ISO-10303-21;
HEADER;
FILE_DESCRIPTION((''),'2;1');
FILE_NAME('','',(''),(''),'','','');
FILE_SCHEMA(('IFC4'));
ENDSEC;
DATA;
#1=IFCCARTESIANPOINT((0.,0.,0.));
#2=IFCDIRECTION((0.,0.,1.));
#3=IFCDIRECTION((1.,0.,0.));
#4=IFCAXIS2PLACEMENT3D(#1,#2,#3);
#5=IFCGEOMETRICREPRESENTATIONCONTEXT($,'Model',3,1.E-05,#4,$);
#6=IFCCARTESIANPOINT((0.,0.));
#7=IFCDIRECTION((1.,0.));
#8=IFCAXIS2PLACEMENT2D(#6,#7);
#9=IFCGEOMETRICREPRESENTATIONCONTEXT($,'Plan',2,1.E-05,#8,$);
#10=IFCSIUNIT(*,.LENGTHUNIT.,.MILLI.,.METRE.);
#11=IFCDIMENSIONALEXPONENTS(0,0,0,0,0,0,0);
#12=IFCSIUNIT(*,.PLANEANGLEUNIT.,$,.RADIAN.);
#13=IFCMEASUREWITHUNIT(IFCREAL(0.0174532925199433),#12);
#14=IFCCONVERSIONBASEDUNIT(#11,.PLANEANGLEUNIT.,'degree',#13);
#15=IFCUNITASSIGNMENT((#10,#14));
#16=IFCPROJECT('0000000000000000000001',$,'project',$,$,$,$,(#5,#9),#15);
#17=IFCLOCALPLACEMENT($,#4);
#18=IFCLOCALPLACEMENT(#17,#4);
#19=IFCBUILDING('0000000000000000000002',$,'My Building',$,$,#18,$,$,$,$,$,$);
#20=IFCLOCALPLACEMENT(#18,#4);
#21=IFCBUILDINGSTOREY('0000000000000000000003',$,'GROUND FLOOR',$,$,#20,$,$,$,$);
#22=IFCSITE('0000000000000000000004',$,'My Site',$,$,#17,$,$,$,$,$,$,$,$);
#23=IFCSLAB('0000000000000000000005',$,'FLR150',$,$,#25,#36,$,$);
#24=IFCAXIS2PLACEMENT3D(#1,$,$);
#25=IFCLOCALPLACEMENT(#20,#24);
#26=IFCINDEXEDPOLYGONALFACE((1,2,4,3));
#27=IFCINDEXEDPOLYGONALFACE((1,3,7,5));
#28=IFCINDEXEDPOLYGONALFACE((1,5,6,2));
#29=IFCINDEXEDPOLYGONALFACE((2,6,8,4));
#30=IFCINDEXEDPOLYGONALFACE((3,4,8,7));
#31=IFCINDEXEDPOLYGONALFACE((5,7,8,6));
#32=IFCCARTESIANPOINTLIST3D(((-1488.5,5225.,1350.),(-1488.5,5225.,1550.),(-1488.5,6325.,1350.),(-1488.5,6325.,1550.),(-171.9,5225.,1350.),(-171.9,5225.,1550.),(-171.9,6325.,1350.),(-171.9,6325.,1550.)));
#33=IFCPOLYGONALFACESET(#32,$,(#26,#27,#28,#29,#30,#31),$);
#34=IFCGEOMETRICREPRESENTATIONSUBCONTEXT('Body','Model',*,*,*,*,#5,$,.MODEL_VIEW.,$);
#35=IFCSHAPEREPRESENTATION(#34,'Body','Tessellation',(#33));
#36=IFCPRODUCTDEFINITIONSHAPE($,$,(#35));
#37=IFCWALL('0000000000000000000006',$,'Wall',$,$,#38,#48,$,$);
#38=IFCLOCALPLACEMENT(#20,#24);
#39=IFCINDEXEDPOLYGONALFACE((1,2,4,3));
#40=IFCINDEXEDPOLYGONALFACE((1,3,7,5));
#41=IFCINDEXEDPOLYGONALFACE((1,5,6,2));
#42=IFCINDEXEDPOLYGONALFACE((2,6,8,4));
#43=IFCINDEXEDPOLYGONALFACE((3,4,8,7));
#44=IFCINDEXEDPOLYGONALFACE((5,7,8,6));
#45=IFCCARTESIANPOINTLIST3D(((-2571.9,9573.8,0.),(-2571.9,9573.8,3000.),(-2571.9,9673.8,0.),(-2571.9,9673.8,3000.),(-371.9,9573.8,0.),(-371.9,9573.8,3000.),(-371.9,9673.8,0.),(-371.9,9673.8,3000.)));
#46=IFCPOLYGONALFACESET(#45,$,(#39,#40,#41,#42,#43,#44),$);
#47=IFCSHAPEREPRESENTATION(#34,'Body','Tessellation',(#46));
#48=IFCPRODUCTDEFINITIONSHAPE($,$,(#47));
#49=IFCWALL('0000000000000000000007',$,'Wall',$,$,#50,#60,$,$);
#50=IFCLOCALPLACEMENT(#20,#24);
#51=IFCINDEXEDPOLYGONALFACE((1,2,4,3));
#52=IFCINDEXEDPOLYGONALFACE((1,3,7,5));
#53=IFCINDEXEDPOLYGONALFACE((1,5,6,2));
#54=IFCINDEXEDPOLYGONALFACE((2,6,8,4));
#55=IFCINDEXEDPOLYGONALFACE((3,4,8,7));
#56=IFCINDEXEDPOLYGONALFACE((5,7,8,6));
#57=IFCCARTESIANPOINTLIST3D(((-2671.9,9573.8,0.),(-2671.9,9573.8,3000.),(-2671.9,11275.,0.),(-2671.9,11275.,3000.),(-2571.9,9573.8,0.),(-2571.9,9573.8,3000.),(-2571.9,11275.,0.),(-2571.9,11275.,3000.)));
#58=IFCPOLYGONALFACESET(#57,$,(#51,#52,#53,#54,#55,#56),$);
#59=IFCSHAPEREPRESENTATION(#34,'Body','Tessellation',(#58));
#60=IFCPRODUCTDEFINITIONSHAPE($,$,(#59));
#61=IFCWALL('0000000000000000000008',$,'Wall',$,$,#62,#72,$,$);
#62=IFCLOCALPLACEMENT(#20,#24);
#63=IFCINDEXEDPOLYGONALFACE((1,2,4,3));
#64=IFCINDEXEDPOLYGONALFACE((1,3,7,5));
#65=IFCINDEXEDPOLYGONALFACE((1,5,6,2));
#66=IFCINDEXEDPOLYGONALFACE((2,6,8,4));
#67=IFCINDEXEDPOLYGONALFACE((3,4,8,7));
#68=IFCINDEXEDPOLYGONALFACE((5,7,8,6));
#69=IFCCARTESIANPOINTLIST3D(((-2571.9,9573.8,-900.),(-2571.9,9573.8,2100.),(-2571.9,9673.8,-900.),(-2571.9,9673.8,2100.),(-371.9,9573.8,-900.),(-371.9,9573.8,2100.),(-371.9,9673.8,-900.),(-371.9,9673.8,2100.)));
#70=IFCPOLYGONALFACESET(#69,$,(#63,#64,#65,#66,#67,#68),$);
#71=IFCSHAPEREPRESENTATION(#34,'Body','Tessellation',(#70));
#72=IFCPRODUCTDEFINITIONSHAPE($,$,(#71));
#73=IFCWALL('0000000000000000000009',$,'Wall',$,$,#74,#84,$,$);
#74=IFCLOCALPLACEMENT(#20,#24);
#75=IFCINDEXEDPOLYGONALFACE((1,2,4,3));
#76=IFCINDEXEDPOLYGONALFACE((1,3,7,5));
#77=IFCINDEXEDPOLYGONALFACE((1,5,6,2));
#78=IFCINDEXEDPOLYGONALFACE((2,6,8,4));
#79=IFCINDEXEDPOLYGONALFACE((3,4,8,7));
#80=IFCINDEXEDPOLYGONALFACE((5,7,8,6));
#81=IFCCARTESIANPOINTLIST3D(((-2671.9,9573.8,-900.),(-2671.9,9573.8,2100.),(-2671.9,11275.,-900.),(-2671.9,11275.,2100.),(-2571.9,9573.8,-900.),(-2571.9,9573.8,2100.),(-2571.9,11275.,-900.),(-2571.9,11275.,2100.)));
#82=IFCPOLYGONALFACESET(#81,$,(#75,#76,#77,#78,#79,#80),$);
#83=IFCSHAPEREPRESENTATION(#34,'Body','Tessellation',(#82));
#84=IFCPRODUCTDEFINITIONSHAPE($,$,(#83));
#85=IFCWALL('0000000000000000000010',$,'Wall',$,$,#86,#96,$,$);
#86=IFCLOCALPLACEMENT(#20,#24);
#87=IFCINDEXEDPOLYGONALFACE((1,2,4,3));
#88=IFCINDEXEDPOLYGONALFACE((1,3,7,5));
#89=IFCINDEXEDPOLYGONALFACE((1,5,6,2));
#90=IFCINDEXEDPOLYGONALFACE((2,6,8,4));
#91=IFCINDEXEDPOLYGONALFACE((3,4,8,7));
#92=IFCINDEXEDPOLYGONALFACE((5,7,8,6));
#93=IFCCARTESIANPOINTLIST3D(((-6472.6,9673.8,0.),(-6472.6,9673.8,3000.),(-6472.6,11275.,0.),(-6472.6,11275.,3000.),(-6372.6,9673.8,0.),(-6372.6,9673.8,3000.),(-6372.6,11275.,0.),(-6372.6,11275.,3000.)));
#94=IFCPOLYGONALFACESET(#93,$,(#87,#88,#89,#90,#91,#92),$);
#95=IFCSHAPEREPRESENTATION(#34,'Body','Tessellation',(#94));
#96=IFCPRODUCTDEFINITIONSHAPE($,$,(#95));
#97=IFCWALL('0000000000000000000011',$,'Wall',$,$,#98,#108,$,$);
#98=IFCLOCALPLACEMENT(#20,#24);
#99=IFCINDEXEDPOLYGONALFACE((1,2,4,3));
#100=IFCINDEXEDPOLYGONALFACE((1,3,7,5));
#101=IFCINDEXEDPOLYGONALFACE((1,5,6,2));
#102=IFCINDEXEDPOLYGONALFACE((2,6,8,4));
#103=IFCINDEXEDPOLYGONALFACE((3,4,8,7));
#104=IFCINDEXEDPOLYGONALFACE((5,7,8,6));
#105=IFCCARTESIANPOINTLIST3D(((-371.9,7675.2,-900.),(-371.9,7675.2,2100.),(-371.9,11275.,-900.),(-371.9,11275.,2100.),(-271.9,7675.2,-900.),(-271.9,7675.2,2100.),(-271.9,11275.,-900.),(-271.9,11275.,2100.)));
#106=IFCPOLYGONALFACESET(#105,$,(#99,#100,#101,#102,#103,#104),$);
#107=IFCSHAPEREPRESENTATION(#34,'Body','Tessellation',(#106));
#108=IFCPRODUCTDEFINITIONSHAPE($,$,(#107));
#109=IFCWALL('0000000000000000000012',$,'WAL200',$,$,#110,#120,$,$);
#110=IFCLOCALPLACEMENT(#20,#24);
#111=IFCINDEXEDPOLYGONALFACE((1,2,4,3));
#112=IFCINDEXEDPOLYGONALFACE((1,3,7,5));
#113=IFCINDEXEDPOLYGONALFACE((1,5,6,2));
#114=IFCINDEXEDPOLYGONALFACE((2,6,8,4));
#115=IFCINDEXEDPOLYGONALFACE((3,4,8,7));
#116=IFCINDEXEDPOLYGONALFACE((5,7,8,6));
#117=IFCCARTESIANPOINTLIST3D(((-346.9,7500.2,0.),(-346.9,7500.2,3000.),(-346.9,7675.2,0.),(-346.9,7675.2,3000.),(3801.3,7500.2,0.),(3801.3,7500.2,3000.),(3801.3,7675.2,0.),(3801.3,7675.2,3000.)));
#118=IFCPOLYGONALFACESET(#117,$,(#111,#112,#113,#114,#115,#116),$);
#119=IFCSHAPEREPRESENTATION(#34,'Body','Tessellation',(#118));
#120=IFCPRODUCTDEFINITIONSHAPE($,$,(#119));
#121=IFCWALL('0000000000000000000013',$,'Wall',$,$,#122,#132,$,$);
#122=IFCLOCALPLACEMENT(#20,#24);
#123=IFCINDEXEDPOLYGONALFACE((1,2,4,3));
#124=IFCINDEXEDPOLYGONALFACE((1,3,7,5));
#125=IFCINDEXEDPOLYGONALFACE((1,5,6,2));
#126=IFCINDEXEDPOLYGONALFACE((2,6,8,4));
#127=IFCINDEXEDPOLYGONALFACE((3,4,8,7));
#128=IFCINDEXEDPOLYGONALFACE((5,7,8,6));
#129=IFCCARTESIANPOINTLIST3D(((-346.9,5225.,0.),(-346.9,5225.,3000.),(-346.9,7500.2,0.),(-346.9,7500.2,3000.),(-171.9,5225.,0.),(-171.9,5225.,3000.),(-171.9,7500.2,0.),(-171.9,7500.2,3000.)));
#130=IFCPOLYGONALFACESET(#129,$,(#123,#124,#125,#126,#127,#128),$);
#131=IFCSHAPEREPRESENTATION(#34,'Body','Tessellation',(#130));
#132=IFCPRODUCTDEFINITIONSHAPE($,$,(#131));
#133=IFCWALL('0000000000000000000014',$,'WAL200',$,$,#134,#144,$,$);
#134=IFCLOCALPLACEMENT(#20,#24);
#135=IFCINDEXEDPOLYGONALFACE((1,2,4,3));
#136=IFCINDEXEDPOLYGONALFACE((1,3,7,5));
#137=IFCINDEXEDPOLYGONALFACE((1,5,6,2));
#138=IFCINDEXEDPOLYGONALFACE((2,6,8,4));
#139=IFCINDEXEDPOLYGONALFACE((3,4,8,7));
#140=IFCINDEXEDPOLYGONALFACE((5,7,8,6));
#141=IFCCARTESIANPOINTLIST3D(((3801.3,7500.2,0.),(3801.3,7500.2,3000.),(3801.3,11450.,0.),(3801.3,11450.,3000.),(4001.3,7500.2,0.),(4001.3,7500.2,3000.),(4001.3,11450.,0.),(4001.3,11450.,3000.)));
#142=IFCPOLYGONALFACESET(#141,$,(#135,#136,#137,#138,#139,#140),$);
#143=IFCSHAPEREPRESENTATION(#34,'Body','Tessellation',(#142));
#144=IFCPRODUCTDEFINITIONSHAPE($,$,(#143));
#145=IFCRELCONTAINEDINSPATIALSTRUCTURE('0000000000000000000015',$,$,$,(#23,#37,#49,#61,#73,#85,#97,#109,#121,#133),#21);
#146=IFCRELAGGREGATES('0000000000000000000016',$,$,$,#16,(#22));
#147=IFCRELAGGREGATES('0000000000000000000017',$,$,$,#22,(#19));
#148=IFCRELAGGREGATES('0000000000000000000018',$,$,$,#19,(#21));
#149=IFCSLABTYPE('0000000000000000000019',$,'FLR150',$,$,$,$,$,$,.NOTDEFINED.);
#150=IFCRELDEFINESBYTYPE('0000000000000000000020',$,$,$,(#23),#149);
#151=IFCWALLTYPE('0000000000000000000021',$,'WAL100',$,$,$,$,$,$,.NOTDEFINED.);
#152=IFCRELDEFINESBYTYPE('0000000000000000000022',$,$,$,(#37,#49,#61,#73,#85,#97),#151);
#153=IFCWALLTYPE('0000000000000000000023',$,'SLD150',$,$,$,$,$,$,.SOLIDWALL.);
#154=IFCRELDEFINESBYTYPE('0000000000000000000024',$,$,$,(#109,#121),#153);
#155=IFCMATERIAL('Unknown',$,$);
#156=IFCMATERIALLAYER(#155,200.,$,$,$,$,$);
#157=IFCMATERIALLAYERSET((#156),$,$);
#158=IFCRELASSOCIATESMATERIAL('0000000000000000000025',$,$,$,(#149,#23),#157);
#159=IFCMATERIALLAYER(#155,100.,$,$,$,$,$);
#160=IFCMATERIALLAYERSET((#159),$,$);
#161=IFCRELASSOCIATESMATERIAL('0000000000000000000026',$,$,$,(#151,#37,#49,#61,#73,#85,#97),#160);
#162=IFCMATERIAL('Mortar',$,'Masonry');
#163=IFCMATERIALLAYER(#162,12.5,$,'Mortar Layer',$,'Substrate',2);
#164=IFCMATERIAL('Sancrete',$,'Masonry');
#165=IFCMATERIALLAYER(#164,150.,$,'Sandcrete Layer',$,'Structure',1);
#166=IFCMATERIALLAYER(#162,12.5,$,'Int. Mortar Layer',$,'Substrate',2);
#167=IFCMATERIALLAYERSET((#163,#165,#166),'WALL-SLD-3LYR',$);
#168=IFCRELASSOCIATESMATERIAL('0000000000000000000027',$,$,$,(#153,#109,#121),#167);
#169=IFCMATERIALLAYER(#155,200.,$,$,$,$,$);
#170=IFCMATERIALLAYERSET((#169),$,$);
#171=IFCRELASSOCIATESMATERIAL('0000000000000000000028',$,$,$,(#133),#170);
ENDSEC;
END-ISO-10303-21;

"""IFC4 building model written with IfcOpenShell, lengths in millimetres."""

from ifc_helpers import new_model, entity, si_unit, converted_unit, frame, origin_with_axes, origin_2d_with_axis, place, context, subcontext, project, spatial, line, indexed_curve, outline, extrude, material, layer, layer_set, layer_usage, type_object, element, save


model = new_model("IFC4")

# Units and contexts
model_context = context("Model", 3, precision=1e-05, world=origin_with_axes())
plan_context = context("Plan", 2, precision=1e-05, world=origin_2d_with_axis())
body_context_1 = subcontext(model_context, "Body", "Model", "MODEL_VIEW")
ifc_project = project(units=[si_unit("LENGTHUNIT", "METRE", prefix="MILLI"), converted_unit("PLANEANGLEUNIT", "degree", entity("IfcReal", 0.0174532925199433), si_unit("PLANEANGLEUNIT", "RADIAN"), dimensions=[0, 0, 0, 0, 0, 0, 0])], contexts=[model_context, plan_context])

# Site, building, storey
site_placement = place(None, origin_with_axes())
site = spatial("IfcSite", under=ifc_project, at=site_placement, Name="My Site")
building_placement = place(site_placement, origin_with_axes())
building = spatial("IfcBuilding", under=site, at=building_placement, Name="My Building")
storey_placement = place(building_placement, origin_with_axes())
storey = spatial("IfcBuildingStorey", under=building, at=storey_placement, Name="GROUND FLOOR")

# Slab
ifc_material_1 = material(Name="Unknown")
ifc_layer_1 = layer(ifc_material_1, 200.0)
ifc_layer_set_1 = layer_set([ifc_layer_1])
ifc_layer_usage_1 = layer_usage(ifc_layer_set_1, "AXIS3", "POSITIVE", 0.0)
slab_type = type_object("IfcSlabType", Name="FLR150", PredefinedType="NOTDEFINED", material=ifc_layer_set_1)
slab_placement = place(storey_placement, frame((-1488.5, 5225.0, 1350.0), z_axis=(0.0, 0.0, 1.0), x_axis=(1.0, 0.0, 0.0)))
element("IfcSlab", 1, at=slab_placement, inside=storey, type_object=slab_type, material=ifc_layer_usage_1, Name="FLR150", context=body_context_1, shape_type="SweptSolid", body=[
    extrude(outline(indexed_curve([(0.0, 0.0), (1316.6, 0.0), (1316.6, 1100.0), (0.0, 1100.0)], segments=[line(4, 1), line(1, 2), line(2, 3), line(3, 4)], self_intersect=False)), None, (0.0, 0.0, 1.0), 200.0),
])

# Shared definitions
ifc_layer_2 = layer(ifc_material_1, 100.0)
ifc_layer_set_2 = layer_set([ifc_layer_2])
wall_type_1 = type_object("IfcWallType", Name="WAL100", PredefinedType="NOTDEFINED", material=ifc_layer_set_2)

# Walls
ifc_layer_usage_2 = layer_usage(ifc_layer_set_2, "AXIS2", "POSITIVE", 0.0)
wall_1_placement = place(storey_placement, frame((-371.9, 9673.8, 0.0), z_axis=(0.0, 0.0, 1.0), x_axis=(-1.0, 0.0, 0.0)))
element("IfcWall", 2, at=wall_1_placement, inside=storey, type_object=wall_type_1, material=ifc_layer_usage_2, Name="Wall", context=body_context_1, shape_type="SweptSolid", body=[
    extrude(outline(indexed_curve([(0.0, 0.0), (0.0, 100.0), (2200.0, 100.0), (2200.0, 0.0), (0.0, 0.0)], self_intersect=False)), origin_with_axes(), (0.0, 0.0, 1.0), 3000.0),
])
ifc_layer_usage_3 = layer_usage(ifc_layer_set_2, "AXIS2", "POSITIVE", 0.0)
wall_2_placement = place(storey_placement, frame((-2571.9, 9573.8, 0.0), z_axis=(0.0, 0.0, 1.0), x_axis=(0.0, 1.0, 0.0)))
element("IfcWall", 3, at=wall_2_placement, inside=storey, type_object=wall_type_1, material=ifc_layer_usage_3, Name="Wall", context=body_context_1, shape_type="SweptSolid", body=[
    extrude(outline(indexed_curve([(0.0, 0.0), (0.0, 100.0), (1701.2, 100.0), (1701.2, 0.0), (0.0, 0.0)], self_intersect=False)), origin_with_axes(), (0.0, 0.0, 1.0), 3000.0),
])
ifc_layer_usage_4 = layer_usage(ifc_layer_set_2, "AXIS2", "POSITIVE", 0.0)
wall_3_placement = place(storey_placement, frame((-371.9, 9673.8, -900.0), z_axis=(0.0, 0.0, 1.0), x_axis=(-1.0, 0.0, 0.0)))
element("IfcWall", 4, at=wall_3_placement, inside=storey, type_object=wall_type_1, material=ifc_layer_usage_4, Name="Wall", context=body_context_1, shape_type="SweptSolid", body=[
    extrude(outline(indexed_curve([(0.0, 0.0), (0.0, 100.0), (2200.0, 100.0), (2200.0, 0.0), (0.0, 0.0)], self_intersect=False)), origin_with_axes(), (0.0, 0.0, 1.0), 3000.0),
])
ifc_layer_usage_5 = layer_usage(ifc_layer_set_2, "AXIS2", "POSITIVE", 0.0)
wall_4_placement = place(storey_placement, frame((-2571.9, 9573.8, -900.0), z_axis=(0.0, 0.0, 1.0), x_axis=(0.0, 1.0, 0.0)))
element("IfcWall", 5, at=wall_4_placement, inside=storey, type_object=wall_type_1, material=ifc_layer_usage_5, Name="Wall", context=body_context_1, shape_type="SweptSolid", body=[
    extrude(outline(indexed_curve([(0.0, 0.0), (0.0, 100.0), (1701.2, 100.0), (1701.2, 0.0), (0.0, 0.0)], self_intersect=False)), origin_with_axes(), (0.0, 0.0, 1.0), 3000.0),
])
ifc_layer_usage_6 = layer_usage(ifc_layer_set_2, "AXIS2", "POSITIVE", 0.0)
wall_5_placement = place(storey_placement, frame((-6372.6, 9673.8, 0.0), z_axis=(0.0, 0.0, 1.0), x_axis=(0.000001, 1.0, 0.0)))
element("IfcWall", 6, at=wall_5_placement, inside=storey, type_object=wall_type_1, material=ifc_layer_usage_6, Name="Wall", context=body_context_1, shape_type="SweptSolid", body=[
    extrude(outline(indexed_curve([(0.0, 0.0), (0.0, 100.0), (1601.2, 100.0), (1601.2, 0.0), (0.0, 0.0)], self_intersect=False)), origin_with_axes(), (0.0, 0.0, 1.0), 3000.0),
])
ifc_layer_usage_7 = layer_usage(ifc_layer_set_2, "AXIS2", "POSITIVE", 0.0)
wall_6_placement = place(storey_placement, frame((-271.9, 7675.2, -900.0), z_axis=(0.0, 0.0, 1.0), x_axis=(0.0, 1.0, 0.0)))
element("IfcWall", 7, at=wall_6_placement, inside=storey, type_object=wall_type_1, material=ifc_layer_usage_7, Name="Wall", context=body_context_1, shape_type="SweptSolid", body=[
    extrude(outline(indexed_curve([(0.0, 0.0), (0.0, 100.0), (3599.8, 100.0), (3599.8, 0.0), (0.0, 0.0)], self_intersect=False)), origin_with_axes(), (0.0, 0.0, 1.0), 3000.0),
])
ifc_material_2 = material(Name="Mortar", Category="Masonry")
ifc_layer_3 = layer(ifc_material_2, 12.5, Name="Mortar Layer", Category="Substrate", Priority=2)
ifc_material_3 = material(Name="Sancrete", Category="Masonry")
ifc_layer_4 = layer(ifc_material_3, 150.0, Name="Sandcrete Layer", Category="Structure", Priority=1)
ifc_layer_5 = layer(ifc_material_2, 12.5, Name="Int. Mortar Layer", Category="Substrate", Priority=2)
ifc_layer_set_3 = layer_set([ifc_layer_3, ifc_layer_4, ifc_layer_5], Name="WALL-SLD-3LYR")
ifc_layer_usage_8 = layer_usage(ifc_layer_set_3, "AXIS2", "POSITIVE", 0.0)
wall_type_2 = type_object("IfcWallType", Name="SLD150", PredefinedType="SOLIDWALL", material=ifc_layer_set_3)
wall_7_placement = place(storey_placement, frame((3801.3, 7675.2, 0.0), z_axis=(0.0, 0.0, 1.0), x_axis=(-1.0, 0.0, 0.0)))
element("IfcWall", 8, at=wall_7_placement, inside=storey, type_object=wall_type_2, material=ifc_layer_usage_8, Name="WAL200", context=body_context_1, shape_type="SweptSolid", body=[
    extrude(outline(indexed_curve([(0.0, 0.0), (0.0, 175.0), (4148.2, 175.0), (4148.2, 0.0), (0.0, 0.0)], self_intersect=False)), origin_with_axes(), (0.0, 0.0, 1.0), 3000.0),
])
ifc_layer_usage_9 = layer_usage(ifc_layer_set_3, "AXIS2", "POSITIVE", 0.0)
wall_8_placement = place(storey_placement, frame((-171.9, 5225.0, 0.0), z_axis=(0.0, 0.0, 1.0), x_axis=(0.0, 1.0, 0.0)))
element("IfcWall", 9, at=wall_8_placement, inside=storey, type_object=wall_type_2, material=ifc_layer_usage_9, Name="Wall", context=body_context_1, shape_type="SweptSolid", body=[
    extrude(outline(indexed_curve([(0.0, 0.0), (0.0, 175.0), (2275.2, 175.0), (2275.2, 0.0), (0.0, 0.0)], self_intersect=False)), origin_with_axes(), (0.0, 0.0, 1.0), 3000.0),
])
ifc_layer_6 = layer(ifc_material_1, 200.0)
ifc_layer_set_4 = layer_set([ifc_layer_6])
ifc_layer_usage_10 = layer_usage(ifc_layer_set_4, "AXIS2", "POSITIVE", 0.0)
wall_9_placement = place(storey_placement, frame((3801.3, 11450.0, 0.0), z_axis=(0.0, 0.0, 1.0), x_axis=(-0.000001, -1.0, 0.0)))
element("IfcWall", 10, at=wall_9_placement, inside=storey, material=ifc_layer_usage_10, Name="WAL200", context=body_context_1, shape_type="SweptSolid", body=[
    extrude(outline(indexed_curve([(0.0, 0.0), (0.0, 200.0), (3949.8, 200.0), (3949.8, 0.0), (0.0, 0.0)], self_intersect=False)), origin_with_axes(), (0.0, 0.0, 1.0), 3000.0),
])

save(model, "model.ifc")
